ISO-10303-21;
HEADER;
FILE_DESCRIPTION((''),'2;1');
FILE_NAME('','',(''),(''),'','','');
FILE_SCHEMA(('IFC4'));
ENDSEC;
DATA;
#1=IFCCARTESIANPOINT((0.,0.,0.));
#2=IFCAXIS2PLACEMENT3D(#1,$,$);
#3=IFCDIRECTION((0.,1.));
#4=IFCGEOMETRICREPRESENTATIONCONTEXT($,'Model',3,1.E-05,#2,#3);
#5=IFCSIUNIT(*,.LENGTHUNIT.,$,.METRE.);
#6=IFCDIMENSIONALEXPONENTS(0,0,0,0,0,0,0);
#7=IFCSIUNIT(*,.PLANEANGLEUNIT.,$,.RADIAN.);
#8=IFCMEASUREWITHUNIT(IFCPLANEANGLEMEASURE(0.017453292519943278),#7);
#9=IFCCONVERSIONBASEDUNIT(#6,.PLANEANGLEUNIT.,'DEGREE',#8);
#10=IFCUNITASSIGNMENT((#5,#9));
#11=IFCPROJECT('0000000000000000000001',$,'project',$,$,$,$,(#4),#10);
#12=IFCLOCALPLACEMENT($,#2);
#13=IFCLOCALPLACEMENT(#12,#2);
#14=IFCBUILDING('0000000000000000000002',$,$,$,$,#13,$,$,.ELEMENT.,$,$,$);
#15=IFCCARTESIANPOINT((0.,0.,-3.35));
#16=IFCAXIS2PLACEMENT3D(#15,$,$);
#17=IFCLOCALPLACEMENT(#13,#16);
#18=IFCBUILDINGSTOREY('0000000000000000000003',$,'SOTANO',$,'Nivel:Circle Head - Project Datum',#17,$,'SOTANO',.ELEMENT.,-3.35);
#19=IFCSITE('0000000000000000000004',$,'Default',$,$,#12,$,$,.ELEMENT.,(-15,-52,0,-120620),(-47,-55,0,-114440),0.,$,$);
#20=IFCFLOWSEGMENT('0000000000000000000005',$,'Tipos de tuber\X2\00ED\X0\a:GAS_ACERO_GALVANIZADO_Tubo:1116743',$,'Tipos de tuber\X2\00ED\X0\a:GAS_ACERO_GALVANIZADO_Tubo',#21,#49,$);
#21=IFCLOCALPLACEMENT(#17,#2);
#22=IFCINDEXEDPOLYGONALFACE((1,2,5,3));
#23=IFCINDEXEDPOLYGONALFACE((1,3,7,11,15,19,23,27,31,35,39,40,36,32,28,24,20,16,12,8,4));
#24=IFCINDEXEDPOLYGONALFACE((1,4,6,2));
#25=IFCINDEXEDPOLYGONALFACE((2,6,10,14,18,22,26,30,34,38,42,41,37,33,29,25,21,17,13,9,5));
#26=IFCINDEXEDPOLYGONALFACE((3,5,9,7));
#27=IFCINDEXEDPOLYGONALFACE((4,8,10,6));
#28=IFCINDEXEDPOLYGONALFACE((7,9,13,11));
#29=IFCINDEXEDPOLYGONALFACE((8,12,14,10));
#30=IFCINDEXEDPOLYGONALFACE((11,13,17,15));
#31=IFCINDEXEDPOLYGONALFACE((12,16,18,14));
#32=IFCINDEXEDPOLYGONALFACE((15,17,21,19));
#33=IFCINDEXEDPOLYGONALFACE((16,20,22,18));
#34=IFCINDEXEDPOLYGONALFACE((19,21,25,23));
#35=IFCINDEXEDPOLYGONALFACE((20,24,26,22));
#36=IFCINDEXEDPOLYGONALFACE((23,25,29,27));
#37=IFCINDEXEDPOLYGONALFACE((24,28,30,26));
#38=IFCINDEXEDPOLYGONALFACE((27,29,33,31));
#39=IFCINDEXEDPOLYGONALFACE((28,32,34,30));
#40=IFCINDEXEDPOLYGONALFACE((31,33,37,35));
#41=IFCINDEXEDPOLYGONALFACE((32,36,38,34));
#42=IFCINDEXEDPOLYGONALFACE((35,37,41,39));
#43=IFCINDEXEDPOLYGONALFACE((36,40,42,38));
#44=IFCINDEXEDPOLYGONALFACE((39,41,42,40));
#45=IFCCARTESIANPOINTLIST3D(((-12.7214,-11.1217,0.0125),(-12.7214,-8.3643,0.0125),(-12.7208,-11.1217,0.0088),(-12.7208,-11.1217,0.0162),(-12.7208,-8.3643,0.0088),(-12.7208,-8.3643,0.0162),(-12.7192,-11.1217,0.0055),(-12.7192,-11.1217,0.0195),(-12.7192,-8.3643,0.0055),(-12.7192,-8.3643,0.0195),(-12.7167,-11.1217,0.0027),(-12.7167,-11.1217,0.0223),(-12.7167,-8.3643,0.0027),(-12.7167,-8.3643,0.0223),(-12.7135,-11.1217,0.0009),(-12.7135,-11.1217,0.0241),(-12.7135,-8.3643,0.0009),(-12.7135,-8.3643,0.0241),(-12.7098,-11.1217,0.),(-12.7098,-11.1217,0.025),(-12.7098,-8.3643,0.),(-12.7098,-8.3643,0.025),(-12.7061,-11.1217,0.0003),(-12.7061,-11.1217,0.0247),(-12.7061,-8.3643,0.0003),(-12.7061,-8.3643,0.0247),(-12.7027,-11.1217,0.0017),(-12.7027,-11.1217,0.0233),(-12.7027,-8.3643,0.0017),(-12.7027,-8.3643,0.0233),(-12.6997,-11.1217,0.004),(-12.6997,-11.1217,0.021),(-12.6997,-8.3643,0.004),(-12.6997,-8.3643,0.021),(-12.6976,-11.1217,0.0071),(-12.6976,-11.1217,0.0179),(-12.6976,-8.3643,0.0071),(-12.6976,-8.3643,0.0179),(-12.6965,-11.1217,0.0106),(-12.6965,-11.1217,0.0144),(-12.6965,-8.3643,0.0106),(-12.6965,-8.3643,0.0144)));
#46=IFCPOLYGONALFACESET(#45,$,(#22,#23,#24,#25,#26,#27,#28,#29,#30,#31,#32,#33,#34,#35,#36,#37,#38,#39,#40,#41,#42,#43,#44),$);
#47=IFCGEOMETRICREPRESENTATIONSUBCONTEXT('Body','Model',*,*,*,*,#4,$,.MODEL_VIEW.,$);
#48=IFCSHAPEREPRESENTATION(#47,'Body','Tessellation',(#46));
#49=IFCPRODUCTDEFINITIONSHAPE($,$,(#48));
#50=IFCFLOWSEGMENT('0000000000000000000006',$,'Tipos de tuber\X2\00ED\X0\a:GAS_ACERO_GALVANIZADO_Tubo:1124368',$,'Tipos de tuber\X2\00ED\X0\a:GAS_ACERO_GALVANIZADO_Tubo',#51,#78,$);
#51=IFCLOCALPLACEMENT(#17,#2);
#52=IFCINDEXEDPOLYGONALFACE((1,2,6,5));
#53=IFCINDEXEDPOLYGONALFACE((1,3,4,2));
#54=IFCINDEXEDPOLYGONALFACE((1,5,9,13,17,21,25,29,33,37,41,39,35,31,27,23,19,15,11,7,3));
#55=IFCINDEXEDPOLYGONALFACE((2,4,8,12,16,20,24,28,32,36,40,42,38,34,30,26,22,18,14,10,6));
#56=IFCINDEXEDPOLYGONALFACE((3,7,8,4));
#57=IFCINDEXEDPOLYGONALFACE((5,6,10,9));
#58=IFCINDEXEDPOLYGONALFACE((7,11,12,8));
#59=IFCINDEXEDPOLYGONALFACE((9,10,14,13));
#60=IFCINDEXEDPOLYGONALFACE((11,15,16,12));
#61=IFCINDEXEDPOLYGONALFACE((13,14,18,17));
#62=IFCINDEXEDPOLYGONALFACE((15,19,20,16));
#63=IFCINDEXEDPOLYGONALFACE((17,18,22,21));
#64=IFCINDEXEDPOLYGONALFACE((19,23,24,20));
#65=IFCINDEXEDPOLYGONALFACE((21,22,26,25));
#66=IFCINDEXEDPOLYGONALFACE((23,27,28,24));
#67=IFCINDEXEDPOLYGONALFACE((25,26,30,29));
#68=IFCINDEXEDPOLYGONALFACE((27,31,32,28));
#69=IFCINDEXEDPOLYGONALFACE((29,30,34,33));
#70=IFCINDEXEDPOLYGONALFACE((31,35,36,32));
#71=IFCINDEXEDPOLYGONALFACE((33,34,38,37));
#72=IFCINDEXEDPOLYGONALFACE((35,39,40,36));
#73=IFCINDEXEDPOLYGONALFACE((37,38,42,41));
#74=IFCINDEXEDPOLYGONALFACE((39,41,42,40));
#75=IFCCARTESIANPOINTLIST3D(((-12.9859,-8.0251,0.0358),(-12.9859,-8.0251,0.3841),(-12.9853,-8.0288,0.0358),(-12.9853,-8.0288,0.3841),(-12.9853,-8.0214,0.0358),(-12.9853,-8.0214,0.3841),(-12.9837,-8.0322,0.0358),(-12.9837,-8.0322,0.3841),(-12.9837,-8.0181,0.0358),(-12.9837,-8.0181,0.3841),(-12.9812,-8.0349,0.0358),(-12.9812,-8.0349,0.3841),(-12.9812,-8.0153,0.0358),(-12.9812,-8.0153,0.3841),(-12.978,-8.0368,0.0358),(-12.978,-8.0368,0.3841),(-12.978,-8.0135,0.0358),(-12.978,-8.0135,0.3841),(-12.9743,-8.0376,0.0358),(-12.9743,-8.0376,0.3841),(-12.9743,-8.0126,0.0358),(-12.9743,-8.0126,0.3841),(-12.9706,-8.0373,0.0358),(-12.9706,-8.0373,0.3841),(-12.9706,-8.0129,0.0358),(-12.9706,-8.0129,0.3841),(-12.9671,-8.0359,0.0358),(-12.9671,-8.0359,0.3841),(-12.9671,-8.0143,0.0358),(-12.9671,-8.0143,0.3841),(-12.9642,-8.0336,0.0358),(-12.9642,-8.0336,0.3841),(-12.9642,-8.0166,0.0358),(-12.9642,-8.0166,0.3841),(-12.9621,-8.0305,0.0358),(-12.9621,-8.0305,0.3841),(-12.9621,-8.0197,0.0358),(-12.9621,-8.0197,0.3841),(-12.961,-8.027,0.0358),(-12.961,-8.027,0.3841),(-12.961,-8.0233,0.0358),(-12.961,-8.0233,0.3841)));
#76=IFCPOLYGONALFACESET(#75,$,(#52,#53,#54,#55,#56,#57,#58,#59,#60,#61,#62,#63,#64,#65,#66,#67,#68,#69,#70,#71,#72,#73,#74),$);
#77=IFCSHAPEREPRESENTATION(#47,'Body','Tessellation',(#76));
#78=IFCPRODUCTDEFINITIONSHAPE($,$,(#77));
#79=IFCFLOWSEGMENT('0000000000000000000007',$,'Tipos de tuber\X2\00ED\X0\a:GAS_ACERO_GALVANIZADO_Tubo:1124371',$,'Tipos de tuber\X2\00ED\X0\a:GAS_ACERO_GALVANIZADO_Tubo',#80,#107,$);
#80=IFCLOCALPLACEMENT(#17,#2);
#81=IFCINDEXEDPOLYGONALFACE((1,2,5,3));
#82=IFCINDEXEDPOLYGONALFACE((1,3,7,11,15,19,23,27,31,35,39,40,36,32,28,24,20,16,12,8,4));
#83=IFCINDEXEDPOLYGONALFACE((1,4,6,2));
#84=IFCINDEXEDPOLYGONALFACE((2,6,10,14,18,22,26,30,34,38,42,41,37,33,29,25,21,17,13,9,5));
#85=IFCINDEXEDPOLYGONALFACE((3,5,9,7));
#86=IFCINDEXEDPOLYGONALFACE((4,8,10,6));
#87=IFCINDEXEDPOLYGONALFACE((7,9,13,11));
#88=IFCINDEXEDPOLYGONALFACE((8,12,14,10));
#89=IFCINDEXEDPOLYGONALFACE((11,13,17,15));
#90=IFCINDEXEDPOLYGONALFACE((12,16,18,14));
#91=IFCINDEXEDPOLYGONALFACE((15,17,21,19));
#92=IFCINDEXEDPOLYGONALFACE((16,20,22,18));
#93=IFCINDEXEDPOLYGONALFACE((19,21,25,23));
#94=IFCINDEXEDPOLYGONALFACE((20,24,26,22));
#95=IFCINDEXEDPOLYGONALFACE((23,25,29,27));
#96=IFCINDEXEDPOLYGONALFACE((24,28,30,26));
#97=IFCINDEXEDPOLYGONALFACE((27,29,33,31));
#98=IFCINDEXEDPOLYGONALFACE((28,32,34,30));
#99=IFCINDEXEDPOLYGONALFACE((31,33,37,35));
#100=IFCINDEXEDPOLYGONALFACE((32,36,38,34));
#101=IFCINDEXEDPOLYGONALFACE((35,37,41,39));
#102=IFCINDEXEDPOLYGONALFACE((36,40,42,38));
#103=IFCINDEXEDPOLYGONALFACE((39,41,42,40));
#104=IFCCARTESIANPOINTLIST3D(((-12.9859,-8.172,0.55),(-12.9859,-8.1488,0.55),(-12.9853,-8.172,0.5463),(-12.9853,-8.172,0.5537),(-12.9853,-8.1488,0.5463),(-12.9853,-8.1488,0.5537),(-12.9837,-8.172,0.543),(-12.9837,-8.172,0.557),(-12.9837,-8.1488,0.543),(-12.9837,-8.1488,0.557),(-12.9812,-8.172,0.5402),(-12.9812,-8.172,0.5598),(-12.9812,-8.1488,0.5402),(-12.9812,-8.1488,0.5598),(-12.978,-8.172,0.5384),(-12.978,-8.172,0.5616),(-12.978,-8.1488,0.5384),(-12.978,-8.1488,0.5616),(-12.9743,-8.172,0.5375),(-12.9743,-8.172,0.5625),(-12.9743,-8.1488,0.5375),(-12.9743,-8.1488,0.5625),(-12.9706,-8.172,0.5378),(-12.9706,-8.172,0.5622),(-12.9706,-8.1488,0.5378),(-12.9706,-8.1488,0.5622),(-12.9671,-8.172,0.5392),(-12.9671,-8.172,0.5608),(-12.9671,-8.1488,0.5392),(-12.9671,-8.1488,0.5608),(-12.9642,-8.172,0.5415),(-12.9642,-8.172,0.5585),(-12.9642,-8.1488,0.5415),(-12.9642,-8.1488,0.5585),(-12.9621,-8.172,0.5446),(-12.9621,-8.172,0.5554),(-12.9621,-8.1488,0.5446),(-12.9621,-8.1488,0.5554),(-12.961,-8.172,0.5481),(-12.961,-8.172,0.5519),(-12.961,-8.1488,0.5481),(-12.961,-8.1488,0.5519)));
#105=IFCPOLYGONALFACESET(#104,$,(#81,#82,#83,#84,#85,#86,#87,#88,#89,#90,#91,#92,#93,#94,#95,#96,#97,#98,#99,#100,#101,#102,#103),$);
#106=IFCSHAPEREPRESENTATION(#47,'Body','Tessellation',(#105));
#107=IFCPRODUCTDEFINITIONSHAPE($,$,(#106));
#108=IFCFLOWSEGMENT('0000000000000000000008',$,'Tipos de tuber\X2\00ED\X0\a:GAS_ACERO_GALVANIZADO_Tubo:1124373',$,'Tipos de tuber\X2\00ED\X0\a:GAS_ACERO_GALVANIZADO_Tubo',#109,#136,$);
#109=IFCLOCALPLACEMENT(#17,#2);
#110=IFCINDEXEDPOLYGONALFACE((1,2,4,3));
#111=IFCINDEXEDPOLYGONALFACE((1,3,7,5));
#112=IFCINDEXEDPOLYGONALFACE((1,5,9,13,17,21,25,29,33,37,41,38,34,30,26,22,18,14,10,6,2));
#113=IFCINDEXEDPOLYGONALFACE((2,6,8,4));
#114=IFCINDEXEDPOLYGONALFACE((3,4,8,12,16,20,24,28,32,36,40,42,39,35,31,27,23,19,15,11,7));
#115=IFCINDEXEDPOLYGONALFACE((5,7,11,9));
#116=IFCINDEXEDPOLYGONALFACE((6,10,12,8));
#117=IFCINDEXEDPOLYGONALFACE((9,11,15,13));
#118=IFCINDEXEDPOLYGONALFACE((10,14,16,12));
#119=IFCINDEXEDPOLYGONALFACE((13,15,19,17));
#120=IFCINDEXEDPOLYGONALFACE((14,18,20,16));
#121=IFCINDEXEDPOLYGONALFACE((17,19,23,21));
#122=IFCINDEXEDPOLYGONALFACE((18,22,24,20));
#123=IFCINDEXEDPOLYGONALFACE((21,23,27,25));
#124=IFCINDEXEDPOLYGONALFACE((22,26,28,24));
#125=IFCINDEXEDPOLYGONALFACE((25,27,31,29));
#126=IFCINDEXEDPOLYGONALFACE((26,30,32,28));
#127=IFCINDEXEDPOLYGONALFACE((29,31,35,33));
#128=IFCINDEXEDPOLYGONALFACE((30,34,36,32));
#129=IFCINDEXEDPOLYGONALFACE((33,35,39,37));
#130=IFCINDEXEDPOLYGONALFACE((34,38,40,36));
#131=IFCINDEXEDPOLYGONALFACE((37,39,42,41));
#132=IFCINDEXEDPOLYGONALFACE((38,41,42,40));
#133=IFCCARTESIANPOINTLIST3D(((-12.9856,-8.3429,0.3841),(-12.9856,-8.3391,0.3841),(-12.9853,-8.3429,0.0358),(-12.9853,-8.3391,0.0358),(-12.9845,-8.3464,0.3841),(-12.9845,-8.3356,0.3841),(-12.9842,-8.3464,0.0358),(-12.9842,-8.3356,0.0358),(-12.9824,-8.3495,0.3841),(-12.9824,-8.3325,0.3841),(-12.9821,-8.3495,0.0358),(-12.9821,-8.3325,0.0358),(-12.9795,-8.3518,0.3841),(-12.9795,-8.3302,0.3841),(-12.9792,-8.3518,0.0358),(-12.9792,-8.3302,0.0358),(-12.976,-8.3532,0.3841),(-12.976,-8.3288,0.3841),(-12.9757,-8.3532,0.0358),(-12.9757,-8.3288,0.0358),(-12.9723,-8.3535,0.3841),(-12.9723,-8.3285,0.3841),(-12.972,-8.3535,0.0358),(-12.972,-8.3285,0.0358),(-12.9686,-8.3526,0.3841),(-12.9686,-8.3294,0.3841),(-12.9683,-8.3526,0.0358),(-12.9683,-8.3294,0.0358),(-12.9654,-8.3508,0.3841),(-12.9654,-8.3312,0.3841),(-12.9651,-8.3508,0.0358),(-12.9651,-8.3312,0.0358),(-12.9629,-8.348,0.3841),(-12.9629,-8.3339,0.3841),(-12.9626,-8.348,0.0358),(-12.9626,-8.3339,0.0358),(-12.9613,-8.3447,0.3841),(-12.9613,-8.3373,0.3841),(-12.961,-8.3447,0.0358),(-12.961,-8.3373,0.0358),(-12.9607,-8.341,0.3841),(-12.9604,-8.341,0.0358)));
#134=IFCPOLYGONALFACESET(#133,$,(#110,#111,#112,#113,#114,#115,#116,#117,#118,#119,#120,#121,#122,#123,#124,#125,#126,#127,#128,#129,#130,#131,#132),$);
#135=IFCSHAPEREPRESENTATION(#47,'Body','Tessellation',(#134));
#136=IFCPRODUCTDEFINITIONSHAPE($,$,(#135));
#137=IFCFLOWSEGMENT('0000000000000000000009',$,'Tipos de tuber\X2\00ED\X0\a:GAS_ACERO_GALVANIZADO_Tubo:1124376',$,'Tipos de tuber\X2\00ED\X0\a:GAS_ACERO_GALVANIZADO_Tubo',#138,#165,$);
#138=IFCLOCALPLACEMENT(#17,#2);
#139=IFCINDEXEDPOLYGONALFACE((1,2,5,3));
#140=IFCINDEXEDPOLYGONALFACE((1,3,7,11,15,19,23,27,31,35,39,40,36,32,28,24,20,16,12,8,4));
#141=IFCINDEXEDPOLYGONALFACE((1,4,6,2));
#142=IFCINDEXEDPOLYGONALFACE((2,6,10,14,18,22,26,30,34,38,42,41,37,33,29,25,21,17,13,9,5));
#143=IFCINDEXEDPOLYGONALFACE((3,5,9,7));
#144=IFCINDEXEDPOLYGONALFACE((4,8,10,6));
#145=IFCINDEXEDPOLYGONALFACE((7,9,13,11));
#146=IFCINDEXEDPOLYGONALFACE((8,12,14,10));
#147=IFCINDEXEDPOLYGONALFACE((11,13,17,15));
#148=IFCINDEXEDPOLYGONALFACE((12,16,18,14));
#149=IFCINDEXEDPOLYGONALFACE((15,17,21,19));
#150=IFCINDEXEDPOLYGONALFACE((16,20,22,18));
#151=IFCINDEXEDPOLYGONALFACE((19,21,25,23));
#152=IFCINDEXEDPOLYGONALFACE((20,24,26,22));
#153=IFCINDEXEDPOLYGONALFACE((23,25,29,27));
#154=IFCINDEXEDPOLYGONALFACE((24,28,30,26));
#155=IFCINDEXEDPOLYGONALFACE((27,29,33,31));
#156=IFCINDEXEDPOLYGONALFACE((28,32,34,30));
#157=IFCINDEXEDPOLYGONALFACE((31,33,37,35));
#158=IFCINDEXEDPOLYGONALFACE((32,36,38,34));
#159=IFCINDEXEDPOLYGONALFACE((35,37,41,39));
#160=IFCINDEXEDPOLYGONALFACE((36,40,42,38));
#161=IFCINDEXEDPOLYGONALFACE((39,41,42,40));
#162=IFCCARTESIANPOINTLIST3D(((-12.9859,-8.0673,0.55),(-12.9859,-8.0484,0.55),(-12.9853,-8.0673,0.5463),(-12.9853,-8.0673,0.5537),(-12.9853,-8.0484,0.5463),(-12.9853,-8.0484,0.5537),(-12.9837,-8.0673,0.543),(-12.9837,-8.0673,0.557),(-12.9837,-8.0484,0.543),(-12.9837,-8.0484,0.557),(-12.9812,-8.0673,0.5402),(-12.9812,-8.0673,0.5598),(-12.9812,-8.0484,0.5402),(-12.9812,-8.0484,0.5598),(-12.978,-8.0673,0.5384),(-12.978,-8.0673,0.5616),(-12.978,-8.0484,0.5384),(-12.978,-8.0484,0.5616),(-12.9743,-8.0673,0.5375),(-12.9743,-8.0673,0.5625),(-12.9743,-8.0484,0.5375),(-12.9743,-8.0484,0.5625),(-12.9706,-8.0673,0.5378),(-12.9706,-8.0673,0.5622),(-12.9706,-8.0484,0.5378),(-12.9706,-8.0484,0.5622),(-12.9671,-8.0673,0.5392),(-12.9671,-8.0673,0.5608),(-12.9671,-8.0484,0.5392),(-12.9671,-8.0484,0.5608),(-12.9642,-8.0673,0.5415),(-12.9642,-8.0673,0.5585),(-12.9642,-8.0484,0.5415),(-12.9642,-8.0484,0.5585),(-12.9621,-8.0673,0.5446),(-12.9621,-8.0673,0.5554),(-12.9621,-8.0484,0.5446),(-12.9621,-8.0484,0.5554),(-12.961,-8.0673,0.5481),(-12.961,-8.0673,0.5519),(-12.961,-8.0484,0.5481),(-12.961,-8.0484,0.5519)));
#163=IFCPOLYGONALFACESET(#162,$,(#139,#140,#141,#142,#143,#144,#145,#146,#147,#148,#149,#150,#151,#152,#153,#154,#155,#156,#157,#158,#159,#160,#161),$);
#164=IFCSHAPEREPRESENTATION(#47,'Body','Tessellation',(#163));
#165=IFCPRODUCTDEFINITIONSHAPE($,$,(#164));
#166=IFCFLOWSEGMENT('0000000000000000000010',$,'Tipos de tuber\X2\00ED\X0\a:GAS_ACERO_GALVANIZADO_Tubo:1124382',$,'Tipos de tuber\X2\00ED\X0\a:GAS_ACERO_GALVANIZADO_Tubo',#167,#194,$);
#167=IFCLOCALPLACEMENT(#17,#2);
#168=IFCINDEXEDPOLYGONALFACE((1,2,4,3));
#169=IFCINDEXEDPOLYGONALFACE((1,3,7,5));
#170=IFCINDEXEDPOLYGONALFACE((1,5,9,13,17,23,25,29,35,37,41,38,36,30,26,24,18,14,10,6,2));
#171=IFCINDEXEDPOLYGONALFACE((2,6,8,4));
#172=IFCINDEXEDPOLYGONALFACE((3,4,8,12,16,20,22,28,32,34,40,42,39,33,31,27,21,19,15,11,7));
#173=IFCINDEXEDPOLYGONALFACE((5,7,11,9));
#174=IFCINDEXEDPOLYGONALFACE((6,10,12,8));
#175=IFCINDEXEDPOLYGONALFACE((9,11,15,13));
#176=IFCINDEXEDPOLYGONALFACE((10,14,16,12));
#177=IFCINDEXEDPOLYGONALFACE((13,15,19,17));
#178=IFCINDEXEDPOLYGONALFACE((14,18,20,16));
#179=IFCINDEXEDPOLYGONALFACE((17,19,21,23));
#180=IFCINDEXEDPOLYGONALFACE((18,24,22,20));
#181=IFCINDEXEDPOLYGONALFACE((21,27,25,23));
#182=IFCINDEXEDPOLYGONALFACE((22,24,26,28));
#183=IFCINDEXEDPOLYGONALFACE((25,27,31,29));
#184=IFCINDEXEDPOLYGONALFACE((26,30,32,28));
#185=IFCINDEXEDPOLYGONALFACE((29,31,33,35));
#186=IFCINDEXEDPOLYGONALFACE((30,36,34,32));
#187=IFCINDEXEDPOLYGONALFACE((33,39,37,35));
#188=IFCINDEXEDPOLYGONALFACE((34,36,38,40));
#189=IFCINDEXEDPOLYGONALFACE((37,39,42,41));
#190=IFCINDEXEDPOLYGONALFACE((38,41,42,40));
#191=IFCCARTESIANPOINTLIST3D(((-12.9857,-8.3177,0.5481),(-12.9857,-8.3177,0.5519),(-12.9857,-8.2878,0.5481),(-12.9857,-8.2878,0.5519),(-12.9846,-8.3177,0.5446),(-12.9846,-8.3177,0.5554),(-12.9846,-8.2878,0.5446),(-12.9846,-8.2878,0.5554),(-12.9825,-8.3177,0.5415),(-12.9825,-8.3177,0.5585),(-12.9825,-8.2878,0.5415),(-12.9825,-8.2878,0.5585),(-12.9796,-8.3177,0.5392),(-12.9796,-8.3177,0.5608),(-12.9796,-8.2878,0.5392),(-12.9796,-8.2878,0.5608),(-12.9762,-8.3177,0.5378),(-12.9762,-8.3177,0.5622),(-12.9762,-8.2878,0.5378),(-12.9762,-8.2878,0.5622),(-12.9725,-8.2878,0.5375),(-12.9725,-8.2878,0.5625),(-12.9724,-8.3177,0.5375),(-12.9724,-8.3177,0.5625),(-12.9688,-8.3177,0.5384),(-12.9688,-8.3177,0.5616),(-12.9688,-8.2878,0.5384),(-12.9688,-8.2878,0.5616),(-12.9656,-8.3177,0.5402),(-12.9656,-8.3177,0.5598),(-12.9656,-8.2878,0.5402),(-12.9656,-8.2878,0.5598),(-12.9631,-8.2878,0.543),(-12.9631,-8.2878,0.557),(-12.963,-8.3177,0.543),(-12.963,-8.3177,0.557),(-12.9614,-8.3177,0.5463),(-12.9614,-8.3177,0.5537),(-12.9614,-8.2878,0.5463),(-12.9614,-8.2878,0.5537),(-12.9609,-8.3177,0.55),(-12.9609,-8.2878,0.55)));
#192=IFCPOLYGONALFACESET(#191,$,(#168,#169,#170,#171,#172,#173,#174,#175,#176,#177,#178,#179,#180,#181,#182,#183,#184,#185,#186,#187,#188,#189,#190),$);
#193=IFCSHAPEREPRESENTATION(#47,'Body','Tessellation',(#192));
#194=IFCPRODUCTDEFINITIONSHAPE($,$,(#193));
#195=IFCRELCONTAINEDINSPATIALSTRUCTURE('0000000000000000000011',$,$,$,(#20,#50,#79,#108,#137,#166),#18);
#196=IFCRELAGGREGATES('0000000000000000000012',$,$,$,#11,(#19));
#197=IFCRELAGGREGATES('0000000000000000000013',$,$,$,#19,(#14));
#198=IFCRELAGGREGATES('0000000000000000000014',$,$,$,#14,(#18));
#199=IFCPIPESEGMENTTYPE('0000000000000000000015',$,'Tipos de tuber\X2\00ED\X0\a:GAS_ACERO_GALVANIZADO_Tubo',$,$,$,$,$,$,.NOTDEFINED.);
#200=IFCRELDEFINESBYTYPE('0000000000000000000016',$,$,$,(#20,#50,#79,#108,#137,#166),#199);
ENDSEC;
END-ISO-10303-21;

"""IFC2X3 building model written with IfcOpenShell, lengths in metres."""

from ifc_helpers import new_model, entity, si_unit, converted_unit, direction, frame, frame_2d, origin, origin_2d_with_axis, place, context, subcontext, project, spatial, circle, extrude, type_object, element, save


model = new_model("IFC2X3")

# Units and contexts
model_context = context("Model", 3, precision=1e-05, world=origin(), true_north=direction((0.0, 1.0)))
body_context = subcontext(model_context, "Body", "Model", "MODEL_VIEW")
ifc_project = project(units=[si_unit("LENGTHUNIT", "METRE"), converted_unit("PLANEANGLEUNIT", "DEGREE", entity("IfcPlaneAngleMeasure", 0.017453292519943278), si_unit("PLANEANGLEUNIT", "RADIAN"), dimensions=[0, 0, 0, 0, 0, 0, 0])], contexts=[model_context])

# Site, building, storey
site_placement = place(None, origin())
site = spatial("IfcSite", under=ifc_project, at=site_placement, Name="Default", CompositionType="ELEMENT", RefLatitude=(-15, -52, 0, -120620), RefLongitude=(-47, -55, 0, -114440), RefElevation=0.0)
building_placement = place(site_placement, origin())
building = spatial("IfcBuilding", under=site, at=building_placement, CompositionType="ELEMENT")
storey_placement = place(building_placement, frame((0.0, 0.0, -3.35)))
storey = spatial("IfcBuildingStorey", under=building, at=storey_placement, Name="SOTANO", ObjectType="Nivel:Circle Head - Project Datum", LongName="SOTANO", CompositionType="ELEMENT", Elevation=-3.35)

# Flow segments
pipe_segment_type_1 = type_object("IfcPipeSegmentType", Name="Tipos de tubería:GAS_ACERO_GALVANIZADO_Tubo", PredefinedType="NOTDEFINED")
flow_segment_1_placement = place(storey_placement, origin())
element("IfcFlowSegment", 1, at=flow_segment_1_placement, inside=storey, type_object=pipe_segment_type_1, Name="Tipos de tubería:GAS_ACERO_GALVANIZADO_Tubo:1116743", ObjectType="Tipos de tubería:GAS_ACERO_GALVANIZADO_Tubo", context=body_context, shape_type="SweptSolid", body=[
    extrude(circle(Radius=0.0125, at=frame_2d((0.0, 0.0), x_axis=(1.0, 0.0))), frame((-12.7089, -11.1217, 0.0125), z_axis=(0.0, 1.0, 0.0), x_axis=(-1.0, 0.0, 0.0)), (0.0, 0.0, 1.0), 2.7574),
])
flow_segment_2_placement = place(storey_placement, origin())
element("IfcFlowSegment", 2, at=flow_segment_2_placement, inside=storey, type_object=pipe_segment_type_1, Name="Tipos de tubería:GAS_ACERO_GALVANIZADO_Tubo:1124368", ObjectType="Tipos de tubería:GAS_ACERO_GALVANIZADO_Tubo", context=body_context, shape_type="SweptSolid", body=[
    extrude(circle(Radius=0.0125, at=frame_2d((0.0, 0.0), x_axis=(1.0, 0.0))), frame((-12.9734, -8.0251, 0.0358), z_axis=(0.0, 0.0, 1.0), x_axis=(-1.0, 0.0, 0.0)), (0.0, 0.0, 1.0), 0.3483),
])
flow_segment_3_placement = place(storey_placement, origin())
element("IfcFlowSegment", 3, at=flow_segment_3_placement, inside=storey, type_object=pipe_segment_type_1, Name="Tipos de tubería:GAS_ACERO_GALVANIZADO_Tubo:1124371", ObjectType="Tipos de tubería:GAS_ACERO_GALVANIZADO_Tubo", context=body_context, shape_type="SweptSolid", body=[
    extrude(circle(Radius=0.0125, at=frame_2d((0.0, 0.0), x_axis=(1.0, 0.0))), frame((-12.9734, -8.172, 0.55), z_axis=(0.0, 1.0, 0.0), x_axis=(-1.0, 0.0, 0.0)), (0.0, 0.0, 1.0), 0.0232),
])
flow_segment_4_placement = place(storey_placement, origin())
element("IfcFlowSegment", 4, at=flow_segment_4_placement, inside=storey, type_object=pipe_segment_type_1, Name="Tipos de tubería:GAS_ACERO_GALVANIZADO_Tubo:1124373", ObjectType="Tipos de tubería:GAS_ACERO_GALVANIZADO_Tubo", context=body_context, shape_type="SweptSolid", body=[
    extrude(circle(Radius=0.0125, at=frame_2d((0.0, 0.0), x_axis=(1.0, 0.0))), frame((-12.9729, -8.341, 0.0358), z_axis=(-0.000874, 0.0, 1.0), x_axis=(1.0, 0.0, 0.000874)), (0.0, 0.0, 1.0), 0.3483),
])
flow_segment_5_placement = place(storey_placement, origin())
element("IfcFlowSegment", 5, at=flow_segment_5_placement, inside=storey, type_object=pipe_segment_type_1, Name="Tipos de tubería:GAS_ACERO_GALVANIZADO_Tubo:1124376", ObjectType="Tipos de tubería:GAS_ACERO_GALVANIZADO_Tubo", context=body_context, shape_type="SweptSolid", body=[
    extrude(circle(Radius=0.0125, at=origin_2d_with_axis()), frame((-12.9734, -8.0673, 0.55), z_axis=(0.0, 1.0, 0.0), x_axis=(-1.0, 0.0, 0.0)), (0.0, 0.0, 1.0), 0.0188),
])
flow_segment_6_placement = place(storey_placement, origin())
element("IfcFlowSegment", 6, at=flow_segment_6_placement, inside=storey, type_object=pipe_segment_type_1, Name="Tipos de tubería:GAS_ACERO_GALVANIZADO_Tubo:1124382", ObjectType="Tipos de tubería:GAS_ACERO_GALVANIZADO_Tubo", context=body_context, shape_type="SweptSolid", body=[
    extrude(circle(Radius=0.0125, at=frame_2d((0.0, 0.0), x_axis=(1.0, 0.0))), frame((-12.9734, -8.2878, 0.55), z_axis=(0.000444, -1.0, 0.0), x_axis=(1.0, 0.000444, 0.0)), (0.0, 0.0, 1.0), 0.0298),
])

save(model, "model.ifc")
